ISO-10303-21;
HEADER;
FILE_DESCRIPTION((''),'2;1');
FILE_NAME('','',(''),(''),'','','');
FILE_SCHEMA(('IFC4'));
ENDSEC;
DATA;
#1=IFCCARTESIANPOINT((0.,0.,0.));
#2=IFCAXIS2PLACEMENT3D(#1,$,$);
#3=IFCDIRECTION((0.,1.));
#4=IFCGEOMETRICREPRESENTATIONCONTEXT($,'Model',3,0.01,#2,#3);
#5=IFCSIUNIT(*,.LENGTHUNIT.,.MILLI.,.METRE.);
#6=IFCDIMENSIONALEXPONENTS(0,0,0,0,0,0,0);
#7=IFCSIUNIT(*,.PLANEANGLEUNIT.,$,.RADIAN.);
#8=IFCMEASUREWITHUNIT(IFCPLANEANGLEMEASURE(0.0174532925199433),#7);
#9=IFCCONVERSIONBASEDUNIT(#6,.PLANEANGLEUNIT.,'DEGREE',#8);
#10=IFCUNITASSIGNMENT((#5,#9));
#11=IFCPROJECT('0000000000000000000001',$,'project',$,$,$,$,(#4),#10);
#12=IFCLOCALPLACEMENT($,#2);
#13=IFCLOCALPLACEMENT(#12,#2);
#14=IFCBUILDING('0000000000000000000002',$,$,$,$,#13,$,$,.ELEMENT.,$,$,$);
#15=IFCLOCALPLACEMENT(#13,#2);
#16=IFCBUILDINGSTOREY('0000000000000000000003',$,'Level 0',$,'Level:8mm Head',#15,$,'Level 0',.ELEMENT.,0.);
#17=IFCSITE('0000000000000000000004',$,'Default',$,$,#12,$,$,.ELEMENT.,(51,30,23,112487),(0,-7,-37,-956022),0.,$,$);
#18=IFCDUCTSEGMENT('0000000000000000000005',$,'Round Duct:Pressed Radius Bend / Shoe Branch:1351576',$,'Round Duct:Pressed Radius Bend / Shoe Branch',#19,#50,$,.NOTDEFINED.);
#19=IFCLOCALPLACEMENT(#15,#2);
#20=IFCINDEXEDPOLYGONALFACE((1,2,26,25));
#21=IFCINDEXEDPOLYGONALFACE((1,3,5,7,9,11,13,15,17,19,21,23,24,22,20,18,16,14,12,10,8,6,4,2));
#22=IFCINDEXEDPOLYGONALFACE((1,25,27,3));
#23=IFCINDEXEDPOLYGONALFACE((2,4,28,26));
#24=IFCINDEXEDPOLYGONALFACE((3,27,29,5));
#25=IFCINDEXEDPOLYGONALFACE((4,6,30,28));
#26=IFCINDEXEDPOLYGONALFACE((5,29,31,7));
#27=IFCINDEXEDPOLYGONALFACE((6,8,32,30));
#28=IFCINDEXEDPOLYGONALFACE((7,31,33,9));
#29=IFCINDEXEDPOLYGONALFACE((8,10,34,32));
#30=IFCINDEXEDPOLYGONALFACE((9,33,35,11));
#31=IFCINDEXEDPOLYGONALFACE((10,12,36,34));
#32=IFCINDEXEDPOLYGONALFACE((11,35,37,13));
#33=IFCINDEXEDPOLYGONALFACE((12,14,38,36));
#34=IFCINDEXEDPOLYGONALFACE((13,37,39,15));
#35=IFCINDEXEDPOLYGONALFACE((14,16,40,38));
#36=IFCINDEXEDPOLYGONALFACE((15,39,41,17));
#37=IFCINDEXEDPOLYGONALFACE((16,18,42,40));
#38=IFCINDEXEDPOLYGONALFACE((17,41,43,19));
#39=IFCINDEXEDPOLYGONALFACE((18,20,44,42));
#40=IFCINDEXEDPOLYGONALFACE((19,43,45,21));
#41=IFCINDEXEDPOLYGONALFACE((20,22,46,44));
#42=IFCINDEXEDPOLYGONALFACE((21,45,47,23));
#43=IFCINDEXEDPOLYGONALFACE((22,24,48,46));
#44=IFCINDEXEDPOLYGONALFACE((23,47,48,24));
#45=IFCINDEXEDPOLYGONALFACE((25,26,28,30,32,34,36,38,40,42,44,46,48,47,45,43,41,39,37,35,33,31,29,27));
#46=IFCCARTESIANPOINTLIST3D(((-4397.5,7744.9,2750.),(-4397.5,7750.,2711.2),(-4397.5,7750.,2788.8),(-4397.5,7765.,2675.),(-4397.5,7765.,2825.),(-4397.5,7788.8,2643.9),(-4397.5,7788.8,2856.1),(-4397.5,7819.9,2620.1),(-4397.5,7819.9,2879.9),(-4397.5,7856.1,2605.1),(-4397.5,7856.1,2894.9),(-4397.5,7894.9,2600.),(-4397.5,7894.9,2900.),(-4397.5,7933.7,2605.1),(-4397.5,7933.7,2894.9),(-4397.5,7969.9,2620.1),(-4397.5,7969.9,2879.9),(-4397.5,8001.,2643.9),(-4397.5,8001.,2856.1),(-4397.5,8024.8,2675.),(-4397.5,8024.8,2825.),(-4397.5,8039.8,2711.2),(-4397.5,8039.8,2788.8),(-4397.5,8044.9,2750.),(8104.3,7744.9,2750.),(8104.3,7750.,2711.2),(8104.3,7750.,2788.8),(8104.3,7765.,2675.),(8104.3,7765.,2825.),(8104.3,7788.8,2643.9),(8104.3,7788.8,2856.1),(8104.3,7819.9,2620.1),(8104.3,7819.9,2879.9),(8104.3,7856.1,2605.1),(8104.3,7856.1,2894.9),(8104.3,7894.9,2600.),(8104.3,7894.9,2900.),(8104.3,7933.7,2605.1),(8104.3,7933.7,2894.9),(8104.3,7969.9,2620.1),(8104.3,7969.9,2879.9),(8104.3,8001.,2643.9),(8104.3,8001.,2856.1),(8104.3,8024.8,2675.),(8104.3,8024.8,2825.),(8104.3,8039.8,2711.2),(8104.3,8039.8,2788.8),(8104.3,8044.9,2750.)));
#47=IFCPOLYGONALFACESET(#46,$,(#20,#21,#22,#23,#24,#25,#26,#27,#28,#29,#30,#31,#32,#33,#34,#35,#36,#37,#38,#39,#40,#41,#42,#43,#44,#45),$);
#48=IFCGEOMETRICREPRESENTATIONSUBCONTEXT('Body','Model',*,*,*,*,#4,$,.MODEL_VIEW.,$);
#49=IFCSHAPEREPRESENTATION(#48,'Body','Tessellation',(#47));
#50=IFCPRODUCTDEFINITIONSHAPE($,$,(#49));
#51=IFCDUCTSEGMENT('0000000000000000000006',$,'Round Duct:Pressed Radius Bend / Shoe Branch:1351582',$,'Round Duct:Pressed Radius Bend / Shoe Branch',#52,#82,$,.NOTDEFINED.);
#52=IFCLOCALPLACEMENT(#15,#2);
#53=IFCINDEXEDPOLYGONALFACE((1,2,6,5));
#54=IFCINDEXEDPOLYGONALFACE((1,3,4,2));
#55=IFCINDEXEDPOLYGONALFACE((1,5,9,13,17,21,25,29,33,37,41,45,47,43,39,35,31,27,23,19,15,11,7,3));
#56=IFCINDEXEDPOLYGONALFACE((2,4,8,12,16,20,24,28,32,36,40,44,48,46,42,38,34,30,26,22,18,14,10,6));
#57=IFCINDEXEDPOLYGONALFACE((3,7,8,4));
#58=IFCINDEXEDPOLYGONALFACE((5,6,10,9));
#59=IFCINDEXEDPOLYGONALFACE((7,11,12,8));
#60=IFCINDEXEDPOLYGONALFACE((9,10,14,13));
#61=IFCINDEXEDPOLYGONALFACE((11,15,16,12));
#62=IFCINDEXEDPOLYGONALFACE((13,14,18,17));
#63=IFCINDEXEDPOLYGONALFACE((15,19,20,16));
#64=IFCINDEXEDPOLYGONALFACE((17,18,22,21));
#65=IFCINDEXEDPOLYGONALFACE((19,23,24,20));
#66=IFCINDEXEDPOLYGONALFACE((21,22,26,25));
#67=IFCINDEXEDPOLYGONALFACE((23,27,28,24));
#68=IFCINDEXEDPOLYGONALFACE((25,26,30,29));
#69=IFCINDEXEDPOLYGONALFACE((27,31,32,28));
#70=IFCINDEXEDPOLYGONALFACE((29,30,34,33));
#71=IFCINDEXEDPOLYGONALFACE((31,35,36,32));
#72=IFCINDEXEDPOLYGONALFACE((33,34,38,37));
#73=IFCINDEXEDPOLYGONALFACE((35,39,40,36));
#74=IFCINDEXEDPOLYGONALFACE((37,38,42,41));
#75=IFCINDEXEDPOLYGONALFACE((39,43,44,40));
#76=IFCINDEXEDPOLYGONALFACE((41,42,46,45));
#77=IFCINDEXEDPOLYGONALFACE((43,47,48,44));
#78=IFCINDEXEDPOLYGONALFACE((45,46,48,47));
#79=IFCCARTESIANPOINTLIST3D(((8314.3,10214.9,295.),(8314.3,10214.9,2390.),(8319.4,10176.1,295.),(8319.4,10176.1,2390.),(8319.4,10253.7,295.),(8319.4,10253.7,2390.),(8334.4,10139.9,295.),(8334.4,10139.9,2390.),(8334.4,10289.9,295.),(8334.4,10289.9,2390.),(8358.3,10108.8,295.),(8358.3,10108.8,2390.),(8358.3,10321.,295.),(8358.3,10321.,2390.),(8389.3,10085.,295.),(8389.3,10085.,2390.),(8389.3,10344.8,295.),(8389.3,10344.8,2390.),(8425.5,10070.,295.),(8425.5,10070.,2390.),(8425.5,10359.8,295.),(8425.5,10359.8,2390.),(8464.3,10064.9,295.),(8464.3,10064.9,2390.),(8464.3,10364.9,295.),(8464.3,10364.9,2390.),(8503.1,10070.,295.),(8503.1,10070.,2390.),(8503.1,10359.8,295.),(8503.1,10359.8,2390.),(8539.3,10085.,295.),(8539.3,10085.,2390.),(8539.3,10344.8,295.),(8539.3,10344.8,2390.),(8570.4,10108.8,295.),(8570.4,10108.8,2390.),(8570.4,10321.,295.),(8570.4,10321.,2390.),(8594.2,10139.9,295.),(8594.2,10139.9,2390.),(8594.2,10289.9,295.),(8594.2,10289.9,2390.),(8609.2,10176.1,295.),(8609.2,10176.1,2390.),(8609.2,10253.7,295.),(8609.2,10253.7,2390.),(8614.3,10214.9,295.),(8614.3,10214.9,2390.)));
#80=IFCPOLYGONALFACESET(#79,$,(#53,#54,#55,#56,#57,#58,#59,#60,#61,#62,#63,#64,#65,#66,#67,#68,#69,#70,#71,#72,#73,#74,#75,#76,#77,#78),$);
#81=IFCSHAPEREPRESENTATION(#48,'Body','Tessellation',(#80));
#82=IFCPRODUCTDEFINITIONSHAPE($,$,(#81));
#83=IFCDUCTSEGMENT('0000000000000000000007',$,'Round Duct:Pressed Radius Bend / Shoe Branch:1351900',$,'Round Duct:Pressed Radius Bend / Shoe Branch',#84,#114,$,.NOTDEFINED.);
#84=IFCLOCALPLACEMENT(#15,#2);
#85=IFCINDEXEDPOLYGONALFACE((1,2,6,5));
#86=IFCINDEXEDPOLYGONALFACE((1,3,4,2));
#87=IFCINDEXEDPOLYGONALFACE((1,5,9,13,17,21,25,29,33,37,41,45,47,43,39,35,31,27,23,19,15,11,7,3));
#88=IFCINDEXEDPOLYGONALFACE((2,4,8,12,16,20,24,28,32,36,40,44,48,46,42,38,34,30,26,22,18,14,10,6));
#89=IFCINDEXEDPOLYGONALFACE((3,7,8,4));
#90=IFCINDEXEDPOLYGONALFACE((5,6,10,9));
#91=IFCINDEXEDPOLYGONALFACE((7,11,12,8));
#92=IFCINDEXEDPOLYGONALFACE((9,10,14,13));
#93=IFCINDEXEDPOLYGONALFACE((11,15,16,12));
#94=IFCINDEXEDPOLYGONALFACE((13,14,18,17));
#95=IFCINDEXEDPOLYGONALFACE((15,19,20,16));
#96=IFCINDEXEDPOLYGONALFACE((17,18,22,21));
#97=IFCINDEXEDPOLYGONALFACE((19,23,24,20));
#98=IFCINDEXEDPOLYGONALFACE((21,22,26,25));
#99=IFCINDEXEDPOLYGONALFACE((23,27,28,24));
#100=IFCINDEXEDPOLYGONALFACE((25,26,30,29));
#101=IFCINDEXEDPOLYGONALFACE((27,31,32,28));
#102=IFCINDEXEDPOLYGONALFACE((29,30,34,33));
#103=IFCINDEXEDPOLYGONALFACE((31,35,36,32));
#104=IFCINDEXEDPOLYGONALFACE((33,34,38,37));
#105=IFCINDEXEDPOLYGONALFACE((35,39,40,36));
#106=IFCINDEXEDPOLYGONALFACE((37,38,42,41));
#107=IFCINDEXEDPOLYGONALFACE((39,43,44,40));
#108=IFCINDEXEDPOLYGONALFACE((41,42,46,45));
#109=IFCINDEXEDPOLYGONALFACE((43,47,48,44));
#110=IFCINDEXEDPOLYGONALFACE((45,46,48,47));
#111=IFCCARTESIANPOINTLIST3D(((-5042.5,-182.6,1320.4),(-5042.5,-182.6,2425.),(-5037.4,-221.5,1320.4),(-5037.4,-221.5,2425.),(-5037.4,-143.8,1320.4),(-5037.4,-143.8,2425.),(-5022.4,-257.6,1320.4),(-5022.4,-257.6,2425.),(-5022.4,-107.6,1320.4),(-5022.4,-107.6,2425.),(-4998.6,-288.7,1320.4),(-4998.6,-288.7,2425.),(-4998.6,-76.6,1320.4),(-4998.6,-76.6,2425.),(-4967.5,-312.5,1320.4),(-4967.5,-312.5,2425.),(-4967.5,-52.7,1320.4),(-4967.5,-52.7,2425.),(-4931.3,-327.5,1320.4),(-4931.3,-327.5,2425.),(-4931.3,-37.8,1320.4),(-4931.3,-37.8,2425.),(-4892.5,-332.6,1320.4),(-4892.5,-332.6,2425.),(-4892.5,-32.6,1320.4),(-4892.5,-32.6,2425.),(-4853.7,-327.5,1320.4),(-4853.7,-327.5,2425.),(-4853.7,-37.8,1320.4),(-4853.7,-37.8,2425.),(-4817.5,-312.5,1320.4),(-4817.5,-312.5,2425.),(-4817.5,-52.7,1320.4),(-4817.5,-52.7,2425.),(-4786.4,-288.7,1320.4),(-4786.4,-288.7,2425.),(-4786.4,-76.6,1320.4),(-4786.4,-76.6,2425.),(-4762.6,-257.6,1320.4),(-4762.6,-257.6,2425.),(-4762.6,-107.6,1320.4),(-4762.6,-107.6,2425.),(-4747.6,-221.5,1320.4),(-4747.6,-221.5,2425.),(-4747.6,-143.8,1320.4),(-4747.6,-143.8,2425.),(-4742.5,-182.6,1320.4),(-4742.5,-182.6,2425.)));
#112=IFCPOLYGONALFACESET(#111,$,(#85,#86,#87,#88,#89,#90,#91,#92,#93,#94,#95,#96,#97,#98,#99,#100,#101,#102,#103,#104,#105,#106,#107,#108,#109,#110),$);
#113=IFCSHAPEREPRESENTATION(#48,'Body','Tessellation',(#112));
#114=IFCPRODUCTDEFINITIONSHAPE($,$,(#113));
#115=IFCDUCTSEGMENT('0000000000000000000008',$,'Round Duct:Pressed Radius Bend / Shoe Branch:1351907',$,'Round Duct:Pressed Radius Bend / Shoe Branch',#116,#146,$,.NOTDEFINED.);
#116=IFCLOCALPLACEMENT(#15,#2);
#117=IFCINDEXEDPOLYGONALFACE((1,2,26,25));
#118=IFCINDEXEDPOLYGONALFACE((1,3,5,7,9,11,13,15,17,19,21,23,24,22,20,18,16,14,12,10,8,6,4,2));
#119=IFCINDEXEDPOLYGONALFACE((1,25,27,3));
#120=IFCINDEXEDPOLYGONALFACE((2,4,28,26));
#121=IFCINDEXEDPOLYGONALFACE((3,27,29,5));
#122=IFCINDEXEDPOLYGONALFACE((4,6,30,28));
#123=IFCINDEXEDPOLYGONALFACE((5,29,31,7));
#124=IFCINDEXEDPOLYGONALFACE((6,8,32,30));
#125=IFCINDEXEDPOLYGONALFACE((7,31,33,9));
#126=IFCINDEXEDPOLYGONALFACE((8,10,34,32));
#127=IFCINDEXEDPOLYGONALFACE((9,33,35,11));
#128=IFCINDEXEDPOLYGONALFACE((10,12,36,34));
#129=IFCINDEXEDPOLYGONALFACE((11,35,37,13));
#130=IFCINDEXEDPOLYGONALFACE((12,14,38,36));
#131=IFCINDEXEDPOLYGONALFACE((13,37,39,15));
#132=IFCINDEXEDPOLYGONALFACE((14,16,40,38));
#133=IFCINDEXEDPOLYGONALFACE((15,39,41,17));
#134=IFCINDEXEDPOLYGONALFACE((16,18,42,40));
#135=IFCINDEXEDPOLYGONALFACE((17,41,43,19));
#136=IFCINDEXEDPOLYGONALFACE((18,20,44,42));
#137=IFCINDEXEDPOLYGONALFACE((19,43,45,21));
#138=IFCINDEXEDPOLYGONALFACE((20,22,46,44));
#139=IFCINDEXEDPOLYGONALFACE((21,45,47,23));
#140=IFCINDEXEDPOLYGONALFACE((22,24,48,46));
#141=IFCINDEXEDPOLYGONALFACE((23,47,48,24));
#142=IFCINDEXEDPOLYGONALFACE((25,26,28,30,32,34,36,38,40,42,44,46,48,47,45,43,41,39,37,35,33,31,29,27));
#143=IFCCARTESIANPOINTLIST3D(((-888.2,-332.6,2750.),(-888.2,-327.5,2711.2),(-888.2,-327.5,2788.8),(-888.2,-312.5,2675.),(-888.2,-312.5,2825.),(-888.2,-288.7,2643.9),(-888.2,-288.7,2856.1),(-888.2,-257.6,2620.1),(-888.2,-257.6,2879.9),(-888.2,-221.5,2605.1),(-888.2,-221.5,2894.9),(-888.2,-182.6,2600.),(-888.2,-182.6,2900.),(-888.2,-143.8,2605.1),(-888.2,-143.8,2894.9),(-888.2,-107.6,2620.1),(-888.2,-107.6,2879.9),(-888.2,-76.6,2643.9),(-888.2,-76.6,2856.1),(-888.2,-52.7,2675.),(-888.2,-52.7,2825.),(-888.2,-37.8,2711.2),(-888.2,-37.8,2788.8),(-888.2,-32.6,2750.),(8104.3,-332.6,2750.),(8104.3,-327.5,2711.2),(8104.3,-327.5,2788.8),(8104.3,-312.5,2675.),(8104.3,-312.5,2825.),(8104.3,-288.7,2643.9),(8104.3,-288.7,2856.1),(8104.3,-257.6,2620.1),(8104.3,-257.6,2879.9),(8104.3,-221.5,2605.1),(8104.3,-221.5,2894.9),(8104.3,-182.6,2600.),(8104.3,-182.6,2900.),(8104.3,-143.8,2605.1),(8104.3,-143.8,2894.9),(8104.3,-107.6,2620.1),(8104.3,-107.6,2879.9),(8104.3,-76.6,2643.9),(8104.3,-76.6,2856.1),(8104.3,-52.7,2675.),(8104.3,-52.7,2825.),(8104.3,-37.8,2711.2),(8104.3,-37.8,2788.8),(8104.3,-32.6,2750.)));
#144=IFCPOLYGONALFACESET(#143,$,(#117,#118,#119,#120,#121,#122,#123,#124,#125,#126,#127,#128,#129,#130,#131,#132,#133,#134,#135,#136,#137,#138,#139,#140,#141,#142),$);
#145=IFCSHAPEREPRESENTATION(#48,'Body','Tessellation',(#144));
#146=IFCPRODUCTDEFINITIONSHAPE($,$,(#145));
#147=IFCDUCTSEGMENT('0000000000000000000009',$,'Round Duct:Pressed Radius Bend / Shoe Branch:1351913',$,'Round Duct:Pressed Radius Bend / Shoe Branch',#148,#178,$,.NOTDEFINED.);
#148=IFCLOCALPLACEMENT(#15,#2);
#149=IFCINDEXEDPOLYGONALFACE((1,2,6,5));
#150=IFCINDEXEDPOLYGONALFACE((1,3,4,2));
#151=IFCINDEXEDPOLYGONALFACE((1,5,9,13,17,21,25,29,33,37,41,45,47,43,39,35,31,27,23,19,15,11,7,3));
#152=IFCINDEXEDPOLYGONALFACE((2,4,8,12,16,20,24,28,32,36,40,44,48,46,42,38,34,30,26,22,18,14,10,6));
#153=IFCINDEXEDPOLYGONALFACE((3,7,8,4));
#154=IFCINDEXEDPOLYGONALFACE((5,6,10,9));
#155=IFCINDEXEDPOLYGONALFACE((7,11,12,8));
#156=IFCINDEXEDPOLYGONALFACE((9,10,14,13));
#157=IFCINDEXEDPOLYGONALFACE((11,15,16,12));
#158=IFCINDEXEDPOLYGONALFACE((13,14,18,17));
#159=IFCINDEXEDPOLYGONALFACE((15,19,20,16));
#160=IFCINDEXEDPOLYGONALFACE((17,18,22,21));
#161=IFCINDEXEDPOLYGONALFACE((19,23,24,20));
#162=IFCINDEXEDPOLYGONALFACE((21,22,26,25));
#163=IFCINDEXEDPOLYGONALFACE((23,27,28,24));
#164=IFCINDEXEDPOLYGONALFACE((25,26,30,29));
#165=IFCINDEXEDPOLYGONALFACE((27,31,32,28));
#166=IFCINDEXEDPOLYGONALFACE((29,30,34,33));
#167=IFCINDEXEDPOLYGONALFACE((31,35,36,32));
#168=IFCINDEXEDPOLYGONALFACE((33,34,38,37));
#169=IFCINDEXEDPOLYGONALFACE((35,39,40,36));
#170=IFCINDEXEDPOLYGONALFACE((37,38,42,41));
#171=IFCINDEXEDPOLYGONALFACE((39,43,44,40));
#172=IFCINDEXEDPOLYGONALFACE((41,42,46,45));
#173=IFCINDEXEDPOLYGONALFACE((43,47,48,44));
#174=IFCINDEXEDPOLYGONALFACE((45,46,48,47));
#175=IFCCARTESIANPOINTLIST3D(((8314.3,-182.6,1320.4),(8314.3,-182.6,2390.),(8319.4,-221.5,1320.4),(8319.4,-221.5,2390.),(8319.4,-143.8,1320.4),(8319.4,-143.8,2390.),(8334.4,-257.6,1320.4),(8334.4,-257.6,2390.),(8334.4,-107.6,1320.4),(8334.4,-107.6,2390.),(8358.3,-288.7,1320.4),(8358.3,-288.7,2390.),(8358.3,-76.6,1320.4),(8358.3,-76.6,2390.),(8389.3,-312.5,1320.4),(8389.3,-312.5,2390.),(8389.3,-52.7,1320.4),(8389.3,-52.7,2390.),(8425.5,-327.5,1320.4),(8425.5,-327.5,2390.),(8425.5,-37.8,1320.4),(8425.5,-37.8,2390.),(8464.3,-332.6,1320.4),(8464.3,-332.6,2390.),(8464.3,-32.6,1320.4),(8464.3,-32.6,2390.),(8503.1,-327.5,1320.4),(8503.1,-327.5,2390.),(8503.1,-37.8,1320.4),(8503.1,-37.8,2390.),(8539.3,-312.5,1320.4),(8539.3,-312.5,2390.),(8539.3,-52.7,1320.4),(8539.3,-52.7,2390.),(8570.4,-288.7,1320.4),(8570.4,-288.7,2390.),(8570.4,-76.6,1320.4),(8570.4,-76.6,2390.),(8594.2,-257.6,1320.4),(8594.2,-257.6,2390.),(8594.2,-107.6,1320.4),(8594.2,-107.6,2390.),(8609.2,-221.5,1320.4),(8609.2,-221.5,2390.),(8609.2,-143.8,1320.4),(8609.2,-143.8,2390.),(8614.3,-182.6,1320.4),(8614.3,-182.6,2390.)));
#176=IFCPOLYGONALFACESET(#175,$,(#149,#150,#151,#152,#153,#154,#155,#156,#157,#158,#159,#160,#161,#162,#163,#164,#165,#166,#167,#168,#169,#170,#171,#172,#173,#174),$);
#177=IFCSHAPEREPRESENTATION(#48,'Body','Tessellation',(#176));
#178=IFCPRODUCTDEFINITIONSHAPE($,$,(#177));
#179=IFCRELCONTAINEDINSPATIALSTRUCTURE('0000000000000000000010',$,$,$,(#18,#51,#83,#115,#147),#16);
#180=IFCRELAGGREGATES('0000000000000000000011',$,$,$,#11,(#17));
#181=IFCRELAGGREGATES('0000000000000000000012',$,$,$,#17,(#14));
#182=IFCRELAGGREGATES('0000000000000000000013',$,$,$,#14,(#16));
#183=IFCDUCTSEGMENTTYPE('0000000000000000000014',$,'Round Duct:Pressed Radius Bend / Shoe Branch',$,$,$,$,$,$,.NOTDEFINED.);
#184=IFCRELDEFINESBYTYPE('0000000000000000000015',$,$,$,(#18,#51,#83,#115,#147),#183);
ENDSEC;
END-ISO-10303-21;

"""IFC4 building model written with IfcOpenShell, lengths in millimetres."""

from ifc_helpers import new_model, entity, si_unit, converted_unit, direction, frame, origin, place, context, subcontext, project, spatial, arc, indexed_curve, outline, extrude, type_object, element, save


model = new_model("IFC4")

# Units and contexts
model_context = context("Model", 3, precision=0.01, world=origin(), true_north=direction((0.0, 1.0)))
body_context = subcontext(model_context, "Body", "Model", "MODEL_VIEW")
ifc_project = project(units=[si_unit("LENGTHUNIT", "METRE", prefix="MILLI"), converted_unit("PLANEANGLEUNIT", "DEGREE", entity("IfcPlaneAngleMeasure", 0.0174532925199433), si_unit("PLANEANGLEUNIT", "RADIAN"), dimensions=[0, 0, 0, 0, 0, 0, 0])], contexts=[model_context])

# Site, building, storey
site_placement = place(None, origin())
site = spatial("IfcSite", under=ifc_project, at=site_placement, Name="Default", CompositionType="ELEMENT", RefLatitude=(51, 30, 23, 112487), RefLongitude=(0, -7, -37, -956022), RefElevation=0.0)
building_placement = place(site_placement, origin())
building = spatial("IfcBuilding", under=site, at=building_placement, CompositionType="ELEMENT")
storey_placement = place(building_placement, origin())
storey = spatial("IfcBuildingStorey", under=building, at=storey_placement, Name="Level 0", ObjectType="Level:8mm Head", LongName="Level 0", CompositionType="ELEMENT", Elevation=0.0)

# Duct segments
duct_segment_type_1 = type_object("IfcDuctSegmentType", Name="Round Duct:Pressed Radius Bend / Shoe Branch", PredefinedType="NOTDEFINED")
duct_segment_1_placement = place(storey_placement, origin())
element("IfcDuctSegment", 1, at=duct_segment_1_placement, inside=storey, type_object=duct_segment_type_1, Name="Round Duct:Pressed Radius Bend / Shoe Branch:1351576", ObjectType="Round Duct:Pressed Radius Bend / Shoe Branch", PredefinedType="NOTDEFINED", context=body_context, shape_type="SweptSolid", body=[
    extrude(outline(indexed_curve([(150.0, 0.0), (106.1, 106.1), (0.0, 150.0), (-106.1, 106.1), (-150.0, 0.0), (-106.1, -106.1), (0.0, -150.0), (106.1, -106.1)], segments=[arc(1, 2, 3), arc(3, 4, 5), arc(5, 6, 7), arc(7, 8, 1)], self_intersect=False)), frame((-4397.5, 7894.9, 2750.0), z_axis=(1.0, 0.0, 0.0), x_axis=(0.0, 1.0, 0.0)), (0.0, 0.0, 1.0), 12501.8),
])
duct_segment_2_placement = place(storey_placement, origin())
element("IfcDuctSegment", 2, at=duct_segment_2_placement, inside=storey, type_object=duct_segment_type_1, Name="Round Duct:Pressed Radius Bend / Shoe Branch:1351582", ObjectType="Round Duct:Pressed Radius Bend / Shoe Branch", PredefinedType="NOTDEFINED", context=body_context, shape_type="SweptSolid", body=[
    extrude(outline(indexed_curve([(150.0, 0.0), (106.1, 106.1), (0.0, 150.0), (-106.1, 106.1), (-150.0, 0.0), (-106.1, -106.1), (0.0, -150.0), (106.1, -106.1)], segments=[arc(1, 2, 3), arc(3, 4, 5), arc(5, 6, 7), arc(7, 8, 1)], self_intersect=False)), frame((8464.3, 10214.9, 295.0)), (0.0, 0.0, 1.0), 2095.0),
])
duct_segment_3_placement = place(storey_placement, origin())
element("IfcDuctSegment", 3, at=duct_segment_3_placement, inside=storey, type_object=duct_segment_type_1, Name="Round Duct:Pressed Radius Bend / Shoe Branch:1351900", ObjectType="Round Duct:Pressed Radius Bend / Shoe Branch", PredefinedType="NOTDEFINED", context=body_context, shape_type="SweptSolid", body=[
    extrude(outline(indexed_curve([(150.0, 0.0), (106.1, 106.1), (0.0, 150.0), (-106.1, 106.1), (-150.0, 0.0), (-106.1, -106.1), (0.0, -150.0), (106.1, -106.1)], segments=[arc(1, 2, 3), arc(3, 4, 5), arc(5, 6, 7), arc(7, 8, 1)], self_intersect=False)), frame((-4892.5, -182.6, 1320.4)), (0.0, 0.0, 1.0), 1104.6),
])
duct_segment_4_placement = place(storey_placement, origin())
element("IfcDuctSegment", 4, at=duct_segment_4_placement, inside=storey, type_object=duct_segment_type_1, Name="Round Duct:Pressed Radius Bend / Shoe Branch:1351907", ObjectType="Round Duct:Pressed Radius Bend / Shoe Branch", PredefinedType="NOTDEFINED", context=body_context, shape_type="SweptSolid", body=[
    extrude(outline(indexed_curve([(150.0, 0.0), (106.1, 106.1), (0.0, 150.0), (-106.1, 106.1), (-150.0, 0.0), (-106.1, -106.1), (0.0, -150.0), (106.1, -106.1)], segments=[arc(1, 2, 3), arc(3, 4, 5), arc(5, 6, 7), arc(7, 8, 1)], self_intersect=False)), frame((-888.2, -182.6, 2750.0), z_axis=(1.0, 0.0, 0.0), x_axis=(0.0, 1.0, 0.0)), (0.0, 0.0, 1.0), 8992.6),
])
duct_segment_5_placement = place(storey_placement, origin())
element("IfcDuctSegment", 5, at=duct_segment_5_placement, inside=storey, type_object=duct_segment_type_1, Name="Round Duct:Pressed Radius Bend / Shoe Branch:1351913", ObjectType="Round Duct:Pressed Radius Bend / Shoe Branch", PredefinedType="NOTDEFINED", context=body_context, shape_type="SweptSolid", body=[
    extrude(outline(indexed_curve([(150.0, 0.0), (106.1, 106.1), (0.0, 150.0), (-106.1, 106.1), (-150.0, 0.0), (-106.1, -106.1), (0.0, -150.0), (106.1, -106.1)], segments=[arc(1, 2, 3), arc(3, 4, 5), arc(5, 6, 7), arc(7, 8, 1)], self_intersect=False)), frame((8464.3, -182.6, 1320.4), z_axis=(0.0, 0.0, 1.0), x_axis=(-1.0, 0.0, 0.0)), (0.0, 0.0, 1.0), 1069.6),
])

save(model, "model.ifc")
